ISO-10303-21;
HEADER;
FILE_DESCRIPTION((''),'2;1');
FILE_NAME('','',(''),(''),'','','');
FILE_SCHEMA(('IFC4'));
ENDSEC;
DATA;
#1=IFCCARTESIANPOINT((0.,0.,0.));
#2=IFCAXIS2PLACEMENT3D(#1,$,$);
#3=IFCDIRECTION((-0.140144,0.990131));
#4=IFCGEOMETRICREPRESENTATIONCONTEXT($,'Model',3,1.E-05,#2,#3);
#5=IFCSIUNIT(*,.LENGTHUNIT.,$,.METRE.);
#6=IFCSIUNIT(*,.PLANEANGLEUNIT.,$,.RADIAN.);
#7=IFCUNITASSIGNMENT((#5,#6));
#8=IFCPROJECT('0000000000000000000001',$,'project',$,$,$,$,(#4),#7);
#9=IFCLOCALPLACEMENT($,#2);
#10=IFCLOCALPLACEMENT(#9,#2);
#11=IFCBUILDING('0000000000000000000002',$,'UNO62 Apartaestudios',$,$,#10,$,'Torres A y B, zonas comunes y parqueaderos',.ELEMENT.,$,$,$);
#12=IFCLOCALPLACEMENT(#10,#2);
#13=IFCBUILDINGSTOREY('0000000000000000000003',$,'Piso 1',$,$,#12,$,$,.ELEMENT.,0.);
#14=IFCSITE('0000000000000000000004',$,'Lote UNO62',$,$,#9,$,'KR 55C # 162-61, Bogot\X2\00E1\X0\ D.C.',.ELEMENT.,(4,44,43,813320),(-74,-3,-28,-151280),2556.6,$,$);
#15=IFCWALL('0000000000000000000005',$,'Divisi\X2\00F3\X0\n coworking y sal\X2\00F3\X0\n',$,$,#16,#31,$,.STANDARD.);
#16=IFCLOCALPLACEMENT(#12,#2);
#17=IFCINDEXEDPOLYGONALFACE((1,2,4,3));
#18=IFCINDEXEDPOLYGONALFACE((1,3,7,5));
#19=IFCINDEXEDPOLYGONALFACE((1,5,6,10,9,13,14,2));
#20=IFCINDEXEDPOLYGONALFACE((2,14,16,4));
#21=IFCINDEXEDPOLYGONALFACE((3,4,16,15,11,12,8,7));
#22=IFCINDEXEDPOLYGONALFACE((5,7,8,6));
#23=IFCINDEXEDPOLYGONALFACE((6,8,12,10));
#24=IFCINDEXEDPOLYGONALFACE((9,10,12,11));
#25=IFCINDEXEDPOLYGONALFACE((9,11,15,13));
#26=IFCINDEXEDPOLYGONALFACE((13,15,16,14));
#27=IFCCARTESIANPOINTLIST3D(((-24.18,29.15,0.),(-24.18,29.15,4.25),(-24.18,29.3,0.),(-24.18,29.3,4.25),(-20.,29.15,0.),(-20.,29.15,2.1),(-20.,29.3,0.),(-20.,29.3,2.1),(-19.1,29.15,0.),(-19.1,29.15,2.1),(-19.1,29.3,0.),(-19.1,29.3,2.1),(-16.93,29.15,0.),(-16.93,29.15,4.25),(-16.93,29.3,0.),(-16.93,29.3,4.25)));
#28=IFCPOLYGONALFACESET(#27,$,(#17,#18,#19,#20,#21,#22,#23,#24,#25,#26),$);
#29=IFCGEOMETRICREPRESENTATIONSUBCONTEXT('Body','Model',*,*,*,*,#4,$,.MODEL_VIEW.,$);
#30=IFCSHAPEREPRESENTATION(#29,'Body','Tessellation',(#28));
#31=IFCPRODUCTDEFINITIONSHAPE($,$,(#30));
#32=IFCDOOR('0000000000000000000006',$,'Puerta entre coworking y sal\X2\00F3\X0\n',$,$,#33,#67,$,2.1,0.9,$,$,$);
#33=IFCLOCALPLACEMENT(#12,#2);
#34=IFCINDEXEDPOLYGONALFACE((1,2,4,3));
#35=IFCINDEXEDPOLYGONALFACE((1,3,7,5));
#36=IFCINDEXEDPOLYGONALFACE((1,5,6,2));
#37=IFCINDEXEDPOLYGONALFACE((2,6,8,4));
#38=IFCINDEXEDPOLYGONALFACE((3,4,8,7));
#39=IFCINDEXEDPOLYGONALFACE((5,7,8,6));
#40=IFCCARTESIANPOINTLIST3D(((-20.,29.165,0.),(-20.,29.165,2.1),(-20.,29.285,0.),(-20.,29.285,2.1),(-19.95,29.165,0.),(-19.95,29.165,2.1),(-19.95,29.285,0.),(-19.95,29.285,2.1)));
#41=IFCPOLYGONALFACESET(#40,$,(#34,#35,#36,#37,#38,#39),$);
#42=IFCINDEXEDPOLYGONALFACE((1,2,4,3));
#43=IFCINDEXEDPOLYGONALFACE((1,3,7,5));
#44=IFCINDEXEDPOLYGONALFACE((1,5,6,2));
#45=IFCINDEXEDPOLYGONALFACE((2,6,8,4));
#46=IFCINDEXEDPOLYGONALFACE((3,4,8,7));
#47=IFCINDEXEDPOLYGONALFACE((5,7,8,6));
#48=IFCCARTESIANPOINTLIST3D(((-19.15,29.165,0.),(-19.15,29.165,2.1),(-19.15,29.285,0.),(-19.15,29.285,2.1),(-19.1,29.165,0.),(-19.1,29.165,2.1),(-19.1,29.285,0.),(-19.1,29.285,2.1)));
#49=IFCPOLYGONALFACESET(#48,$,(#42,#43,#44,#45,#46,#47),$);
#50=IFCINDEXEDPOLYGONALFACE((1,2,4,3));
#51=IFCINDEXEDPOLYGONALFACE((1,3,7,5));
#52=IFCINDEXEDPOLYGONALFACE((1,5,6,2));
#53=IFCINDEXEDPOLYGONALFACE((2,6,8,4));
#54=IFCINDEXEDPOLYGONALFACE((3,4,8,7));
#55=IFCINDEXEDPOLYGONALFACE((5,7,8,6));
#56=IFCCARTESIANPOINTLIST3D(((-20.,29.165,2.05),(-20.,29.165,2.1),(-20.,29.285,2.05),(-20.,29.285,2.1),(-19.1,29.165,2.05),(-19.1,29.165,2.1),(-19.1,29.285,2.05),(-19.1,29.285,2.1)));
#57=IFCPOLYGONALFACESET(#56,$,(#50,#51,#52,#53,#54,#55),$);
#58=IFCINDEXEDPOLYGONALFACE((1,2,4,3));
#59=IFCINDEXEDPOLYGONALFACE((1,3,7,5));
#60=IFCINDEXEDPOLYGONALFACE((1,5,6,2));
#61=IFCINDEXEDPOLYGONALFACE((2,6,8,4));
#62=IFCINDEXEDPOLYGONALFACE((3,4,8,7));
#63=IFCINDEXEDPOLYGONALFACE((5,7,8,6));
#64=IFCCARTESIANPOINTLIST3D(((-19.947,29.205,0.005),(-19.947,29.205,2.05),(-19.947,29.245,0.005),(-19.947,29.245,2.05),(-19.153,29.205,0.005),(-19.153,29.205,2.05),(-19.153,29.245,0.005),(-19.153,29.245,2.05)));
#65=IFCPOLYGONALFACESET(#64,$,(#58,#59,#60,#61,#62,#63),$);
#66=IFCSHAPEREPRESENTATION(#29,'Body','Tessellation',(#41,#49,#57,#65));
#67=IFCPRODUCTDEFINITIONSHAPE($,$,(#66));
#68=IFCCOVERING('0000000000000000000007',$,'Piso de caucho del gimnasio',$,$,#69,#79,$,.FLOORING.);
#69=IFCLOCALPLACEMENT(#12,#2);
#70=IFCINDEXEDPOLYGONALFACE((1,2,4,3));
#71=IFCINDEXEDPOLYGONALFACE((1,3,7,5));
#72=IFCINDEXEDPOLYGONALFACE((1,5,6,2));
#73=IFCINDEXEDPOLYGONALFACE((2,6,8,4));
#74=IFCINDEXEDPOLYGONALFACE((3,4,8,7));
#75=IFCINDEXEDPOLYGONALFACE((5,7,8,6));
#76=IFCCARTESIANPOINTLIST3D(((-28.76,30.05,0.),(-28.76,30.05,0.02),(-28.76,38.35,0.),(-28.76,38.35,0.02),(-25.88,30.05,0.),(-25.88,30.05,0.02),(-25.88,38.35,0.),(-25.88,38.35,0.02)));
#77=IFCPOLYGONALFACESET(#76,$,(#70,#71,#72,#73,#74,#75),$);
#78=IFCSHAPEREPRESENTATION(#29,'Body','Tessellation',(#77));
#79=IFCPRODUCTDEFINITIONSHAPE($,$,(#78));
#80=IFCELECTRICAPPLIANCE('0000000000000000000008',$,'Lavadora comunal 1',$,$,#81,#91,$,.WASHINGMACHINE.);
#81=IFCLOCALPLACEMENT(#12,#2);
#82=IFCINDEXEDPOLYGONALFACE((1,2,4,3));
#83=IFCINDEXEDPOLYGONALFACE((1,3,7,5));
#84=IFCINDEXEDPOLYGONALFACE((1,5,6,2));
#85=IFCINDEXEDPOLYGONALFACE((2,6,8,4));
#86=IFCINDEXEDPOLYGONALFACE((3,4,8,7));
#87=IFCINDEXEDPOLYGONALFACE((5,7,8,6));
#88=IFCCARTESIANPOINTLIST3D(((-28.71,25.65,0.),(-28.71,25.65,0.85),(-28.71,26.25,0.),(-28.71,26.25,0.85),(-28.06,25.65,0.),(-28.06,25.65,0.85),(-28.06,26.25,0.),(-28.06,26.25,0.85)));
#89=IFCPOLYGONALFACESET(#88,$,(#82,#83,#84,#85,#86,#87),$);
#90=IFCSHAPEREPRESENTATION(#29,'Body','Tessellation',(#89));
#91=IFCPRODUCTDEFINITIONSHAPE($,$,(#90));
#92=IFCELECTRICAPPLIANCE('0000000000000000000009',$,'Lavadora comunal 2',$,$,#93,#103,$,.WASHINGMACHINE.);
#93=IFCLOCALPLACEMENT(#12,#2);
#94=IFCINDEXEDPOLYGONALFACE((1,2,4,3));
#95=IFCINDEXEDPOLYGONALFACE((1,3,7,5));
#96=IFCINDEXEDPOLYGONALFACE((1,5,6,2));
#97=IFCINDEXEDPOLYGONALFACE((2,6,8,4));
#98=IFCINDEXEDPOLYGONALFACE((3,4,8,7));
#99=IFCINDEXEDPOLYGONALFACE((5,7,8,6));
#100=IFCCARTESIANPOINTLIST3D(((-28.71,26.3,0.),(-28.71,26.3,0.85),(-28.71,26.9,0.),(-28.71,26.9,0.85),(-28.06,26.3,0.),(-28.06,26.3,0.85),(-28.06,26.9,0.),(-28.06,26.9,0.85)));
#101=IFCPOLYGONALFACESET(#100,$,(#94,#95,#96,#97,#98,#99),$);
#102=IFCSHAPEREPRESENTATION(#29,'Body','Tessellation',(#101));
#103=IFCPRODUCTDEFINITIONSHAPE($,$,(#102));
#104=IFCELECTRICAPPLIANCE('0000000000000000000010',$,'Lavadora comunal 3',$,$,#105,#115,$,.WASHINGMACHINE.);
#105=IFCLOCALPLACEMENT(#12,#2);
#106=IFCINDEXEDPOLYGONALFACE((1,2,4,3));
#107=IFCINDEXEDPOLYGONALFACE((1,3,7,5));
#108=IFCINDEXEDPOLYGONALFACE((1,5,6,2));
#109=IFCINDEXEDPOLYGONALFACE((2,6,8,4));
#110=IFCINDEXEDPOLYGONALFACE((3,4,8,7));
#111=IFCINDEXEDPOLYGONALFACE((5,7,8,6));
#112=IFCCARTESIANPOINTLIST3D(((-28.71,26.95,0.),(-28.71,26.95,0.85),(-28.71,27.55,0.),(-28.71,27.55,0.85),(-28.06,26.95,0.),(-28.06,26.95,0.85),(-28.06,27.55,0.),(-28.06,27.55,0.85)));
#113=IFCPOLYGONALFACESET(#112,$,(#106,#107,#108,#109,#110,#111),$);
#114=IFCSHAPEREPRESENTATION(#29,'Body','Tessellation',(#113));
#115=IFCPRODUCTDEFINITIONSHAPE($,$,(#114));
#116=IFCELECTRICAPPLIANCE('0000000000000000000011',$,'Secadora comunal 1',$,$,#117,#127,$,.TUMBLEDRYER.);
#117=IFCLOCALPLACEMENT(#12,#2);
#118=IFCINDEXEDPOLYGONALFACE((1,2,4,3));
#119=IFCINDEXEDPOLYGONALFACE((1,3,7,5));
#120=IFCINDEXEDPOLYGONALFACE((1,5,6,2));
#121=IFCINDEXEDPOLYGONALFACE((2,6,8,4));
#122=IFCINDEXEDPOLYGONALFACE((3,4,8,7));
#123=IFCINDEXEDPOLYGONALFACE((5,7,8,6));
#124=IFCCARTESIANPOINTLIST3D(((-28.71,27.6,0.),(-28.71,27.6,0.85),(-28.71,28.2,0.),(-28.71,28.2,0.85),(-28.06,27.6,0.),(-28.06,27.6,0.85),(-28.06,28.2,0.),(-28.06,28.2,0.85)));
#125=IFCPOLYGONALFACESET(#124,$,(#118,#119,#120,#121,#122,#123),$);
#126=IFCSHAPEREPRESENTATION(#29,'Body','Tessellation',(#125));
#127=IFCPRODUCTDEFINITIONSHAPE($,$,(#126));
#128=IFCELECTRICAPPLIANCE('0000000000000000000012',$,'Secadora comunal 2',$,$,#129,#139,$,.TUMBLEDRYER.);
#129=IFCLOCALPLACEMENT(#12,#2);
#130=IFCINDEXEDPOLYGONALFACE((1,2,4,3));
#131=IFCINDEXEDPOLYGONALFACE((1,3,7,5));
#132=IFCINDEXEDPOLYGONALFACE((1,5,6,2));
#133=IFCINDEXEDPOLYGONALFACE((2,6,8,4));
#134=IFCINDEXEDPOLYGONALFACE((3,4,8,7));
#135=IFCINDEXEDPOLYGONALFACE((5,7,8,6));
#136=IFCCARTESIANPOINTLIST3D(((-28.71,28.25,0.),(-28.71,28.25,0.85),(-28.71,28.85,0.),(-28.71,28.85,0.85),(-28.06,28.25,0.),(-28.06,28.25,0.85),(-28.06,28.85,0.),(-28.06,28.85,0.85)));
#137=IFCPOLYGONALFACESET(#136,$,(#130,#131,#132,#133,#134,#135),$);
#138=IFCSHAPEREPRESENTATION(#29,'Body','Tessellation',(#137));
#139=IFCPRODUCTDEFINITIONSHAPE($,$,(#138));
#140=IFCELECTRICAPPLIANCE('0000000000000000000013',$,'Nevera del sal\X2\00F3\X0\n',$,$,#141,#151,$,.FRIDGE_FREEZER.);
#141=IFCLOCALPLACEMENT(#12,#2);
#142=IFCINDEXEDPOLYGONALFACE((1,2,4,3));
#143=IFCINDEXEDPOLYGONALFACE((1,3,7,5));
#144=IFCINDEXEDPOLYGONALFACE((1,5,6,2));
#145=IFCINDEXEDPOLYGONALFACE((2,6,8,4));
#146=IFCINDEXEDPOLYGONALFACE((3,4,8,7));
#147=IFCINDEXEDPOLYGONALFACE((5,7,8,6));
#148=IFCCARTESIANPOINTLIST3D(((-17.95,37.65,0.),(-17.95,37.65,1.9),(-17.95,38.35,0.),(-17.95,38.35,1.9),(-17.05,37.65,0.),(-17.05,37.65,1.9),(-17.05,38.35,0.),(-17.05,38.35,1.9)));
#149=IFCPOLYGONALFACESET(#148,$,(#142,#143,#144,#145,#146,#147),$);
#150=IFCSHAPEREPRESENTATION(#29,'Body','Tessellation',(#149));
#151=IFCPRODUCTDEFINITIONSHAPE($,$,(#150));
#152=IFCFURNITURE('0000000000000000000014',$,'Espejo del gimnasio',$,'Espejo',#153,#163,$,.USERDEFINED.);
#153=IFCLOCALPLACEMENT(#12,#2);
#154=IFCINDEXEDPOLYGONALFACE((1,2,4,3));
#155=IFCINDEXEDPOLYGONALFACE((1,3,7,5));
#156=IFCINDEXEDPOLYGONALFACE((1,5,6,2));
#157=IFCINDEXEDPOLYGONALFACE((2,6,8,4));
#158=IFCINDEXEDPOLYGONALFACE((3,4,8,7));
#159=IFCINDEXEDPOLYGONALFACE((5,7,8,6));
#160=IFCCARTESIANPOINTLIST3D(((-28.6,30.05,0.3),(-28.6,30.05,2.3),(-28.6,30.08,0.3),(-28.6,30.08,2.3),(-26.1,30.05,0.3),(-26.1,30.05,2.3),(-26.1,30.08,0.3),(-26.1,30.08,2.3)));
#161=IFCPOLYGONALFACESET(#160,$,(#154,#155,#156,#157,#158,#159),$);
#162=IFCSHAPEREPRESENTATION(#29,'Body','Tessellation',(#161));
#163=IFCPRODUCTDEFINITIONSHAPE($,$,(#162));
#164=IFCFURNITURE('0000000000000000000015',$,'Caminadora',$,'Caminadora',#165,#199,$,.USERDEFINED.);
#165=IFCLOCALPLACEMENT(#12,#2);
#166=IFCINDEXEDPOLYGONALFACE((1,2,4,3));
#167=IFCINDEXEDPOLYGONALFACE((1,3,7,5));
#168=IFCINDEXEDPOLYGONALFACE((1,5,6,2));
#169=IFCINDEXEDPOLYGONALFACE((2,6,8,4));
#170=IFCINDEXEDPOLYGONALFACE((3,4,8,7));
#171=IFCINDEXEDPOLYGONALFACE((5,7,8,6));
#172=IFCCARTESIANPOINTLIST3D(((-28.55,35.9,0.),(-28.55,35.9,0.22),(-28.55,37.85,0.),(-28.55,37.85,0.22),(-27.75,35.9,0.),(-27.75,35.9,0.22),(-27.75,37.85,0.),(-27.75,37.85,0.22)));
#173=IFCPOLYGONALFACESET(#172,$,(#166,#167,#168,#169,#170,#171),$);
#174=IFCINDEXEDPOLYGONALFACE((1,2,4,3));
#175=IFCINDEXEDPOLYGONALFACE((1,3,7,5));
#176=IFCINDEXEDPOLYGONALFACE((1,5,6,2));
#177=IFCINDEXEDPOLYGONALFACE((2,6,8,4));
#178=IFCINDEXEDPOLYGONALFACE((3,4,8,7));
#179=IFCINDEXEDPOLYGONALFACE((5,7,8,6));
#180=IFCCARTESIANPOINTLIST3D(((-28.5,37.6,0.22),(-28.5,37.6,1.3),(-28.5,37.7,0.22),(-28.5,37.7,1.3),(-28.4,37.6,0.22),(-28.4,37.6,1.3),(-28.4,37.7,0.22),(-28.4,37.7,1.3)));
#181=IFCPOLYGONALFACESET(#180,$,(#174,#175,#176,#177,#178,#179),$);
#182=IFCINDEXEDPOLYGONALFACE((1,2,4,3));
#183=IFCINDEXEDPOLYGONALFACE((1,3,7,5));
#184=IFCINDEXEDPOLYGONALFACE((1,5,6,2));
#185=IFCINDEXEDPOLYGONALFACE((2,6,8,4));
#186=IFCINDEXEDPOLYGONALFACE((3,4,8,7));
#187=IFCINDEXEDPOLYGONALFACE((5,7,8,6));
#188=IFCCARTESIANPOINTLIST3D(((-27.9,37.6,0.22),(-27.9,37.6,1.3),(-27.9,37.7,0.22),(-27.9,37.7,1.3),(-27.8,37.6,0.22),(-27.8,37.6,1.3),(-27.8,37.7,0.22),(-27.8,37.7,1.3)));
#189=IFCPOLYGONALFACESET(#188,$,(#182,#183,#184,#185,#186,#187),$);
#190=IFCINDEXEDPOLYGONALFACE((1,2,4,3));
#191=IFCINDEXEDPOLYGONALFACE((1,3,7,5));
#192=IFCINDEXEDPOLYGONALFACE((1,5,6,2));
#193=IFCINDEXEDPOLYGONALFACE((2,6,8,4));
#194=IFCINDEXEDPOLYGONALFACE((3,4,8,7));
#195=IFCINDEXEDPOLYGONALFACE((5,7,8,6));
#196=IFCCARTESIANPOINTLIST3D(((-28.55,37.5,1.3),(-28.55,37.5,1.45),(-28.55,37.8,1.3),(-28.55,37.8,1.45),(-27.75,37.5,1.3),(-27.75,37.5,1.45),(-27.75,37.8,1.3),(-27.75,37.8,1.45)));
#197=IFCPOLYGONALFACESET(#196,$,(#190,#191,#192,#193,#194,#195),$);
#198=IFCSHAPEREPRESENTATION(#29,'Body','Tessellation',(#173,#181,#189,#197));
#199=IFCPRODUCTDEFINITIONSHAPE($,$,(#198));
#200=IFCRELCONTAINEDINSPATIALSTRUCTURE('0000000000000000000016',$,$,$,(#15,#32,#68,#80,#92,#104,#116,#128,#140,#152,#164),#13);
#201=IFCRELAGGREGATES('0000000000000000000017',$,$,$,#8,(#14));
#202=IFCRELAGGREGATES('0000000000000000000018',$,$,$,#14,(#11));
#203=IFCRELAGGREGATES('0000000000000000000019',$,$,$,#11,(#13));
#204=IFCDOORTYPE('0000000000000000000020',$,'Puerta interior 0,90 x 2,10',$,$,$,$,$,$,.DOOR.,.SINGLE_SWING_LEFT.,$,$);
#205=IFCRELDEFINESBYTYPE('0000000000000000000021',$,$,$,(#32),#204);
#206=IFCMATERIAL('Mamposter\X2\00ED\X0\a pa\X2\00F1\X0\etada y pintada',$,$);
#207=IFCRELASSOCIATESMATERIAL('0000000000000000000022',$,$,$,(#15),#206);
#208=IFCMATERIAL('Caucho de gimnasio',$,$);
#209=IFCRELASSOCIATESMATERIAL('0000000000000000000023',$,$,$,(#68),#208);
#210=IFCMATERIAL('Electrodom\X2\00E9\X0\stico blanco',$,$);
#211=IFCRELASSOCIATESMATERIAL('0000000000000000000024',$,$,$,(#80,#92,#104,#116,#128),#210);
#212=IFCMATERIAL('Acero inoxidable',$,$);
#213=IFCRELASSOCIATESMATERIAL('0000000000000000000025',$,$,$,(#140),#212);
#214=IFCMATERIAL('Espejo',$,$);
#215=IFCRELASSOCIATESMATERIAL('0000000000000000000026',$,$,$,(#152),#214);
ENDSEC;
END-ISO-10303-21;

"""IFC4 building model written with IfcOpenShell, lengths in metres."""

from ifc_helpers import new_model, si_unit, direction, frame, frame_2d, origin, place, context, subcontext, project, spatial, rectangle, extrude, source, transform, mapped, material, type_object, type_shapes, element, fill, save


model = new_model("IFC4")

# Units and contexts
model_context = context("Model", 3, precision=1e-05, world=origin(), true_north=direction((-0.140144, 0.990131)))
body_context = subcontext(model_context, "Body", "Model", "MODEL_VIEW")
ifc_project = project(units=[si_unit("LENGTHUNIT", "METRE"), si_unit("PLANEANGLEUNIT", "RADIAN")], contexts=[model_context])

# Site, building, storey
site_placement = place(None, origin())
site = spatial("IfcSite", under=ifc_project, at=site_placement, Name="Lote UNO62", LongName="KR 55C # 162-61, Bogotá D.C.", CompositionType="ELEMENT", RefLatitude=(4, 44, 43, 813320), RefLongitude=(-74, -3, -28, -151280), RefElevation=2556.6)
building_placement = place(site_placement, origin())
building = spatial("IfcBuilding", under=site, at=building_placement, Name="UNO62 Apartaestudios", LongName="Torres A y B, zonas comunes y parqueaderos", CompositionType="ELEMENT")
storey_placement = place(building_placement, origin())
storey = spatial("IfcBuildingStorey", under=building, at=storey_placement, Name="Piso 1", CompositionType="ELEMENT", Elevation=0.0)

# Wall, opening, door
ifc_material_1 = material(Name="Mampostería pañetada y pintada")
wall_placement = place(storey_placement, origin())
wall = element("IfcWall", 1, at=wall_placement, inside=storey, material=ifc_material_1, Name="División coworking y salón", PredefinedType="STANDARD", context=body_context, shape_type="SweptSolid", body=[
    extrude(rectangle(XDim=7.25, YDim=0.15, at=frame_2d((-20.555, 29.225))), origin(), (0.0, 0.0, 1.0), 4.25),
])
opening_placement = place(wall_placement, origin())
opening = element("IfcOpeningElement", 2, at=opening_placement, cuts=wall, PredefinedType="OPENING", context=body_context, shape_type="SweptSolid", body=[
    extrude(rectangle(XDim=0.9, YDim=0.25, at=frame_2d((-19.55, 29.225))), origin(), (0.0, 0.0, 1.0), 2.1),
])
door_type = type_object("IfcDoorType", Name="Puerta interior 0,90 x 2,10", OperationType="SINGLE_SWING_LEFT", PredefinedType="DOOR")
shared_shape = source(origin(), body_context, "Body", "SweptSolid", [
    extrude(rectangle(XDim=0.05, YDim=0.12, at=frame_2d((0.025, 0.0))), origin(), (0.0, 0.0, 1.0), 2.1),
    extrude(rectangle(XDim=0.05, YDim=0.12, at=frame_2d((0.875, 0.0))), origin(), (0.0, 0.0, 1.0), 2.1),
    extrude(rectangle(XDim=0.9, YDim=0.12, at=frame_2d((0.45, 0.0))), frame((0.0, 0.0, 2.05)), (0.0, 0.0, 1.0), 0.05),
    extrude(rectangle(XDim=0.794, YDim=0.04, at=frame_2d((0.45, 0.0))), frame((0.0, 0.0, 0.005)), (0.0, 0.0, 1.0), 2.045),
])
type_shapes(door_type, [shared_shape])
door_placement = place(storey_placement, frame((-20.0, 29.225, 0.0), z_axis=(0.0, 0.0, 1.0), x_axis=(1.0, 0.0, 0.0)))
door = element("IfcDoor", 3, at=door_placement, inside=storey, type_object=door_type, Name="Puerta entre coworking y salón", OverallHeight=2.1, OverallWidth=0.9, context=body_context, shape_type="MappedRepresentation", body=[
    mapped(shared_shape, transform((0.0, 0.0, 0.0))),
])
fill(opening, door)

# Covering
ifc_material_2 = material(Name="Caucho de gimnasio")
covering_placement = place(storey_placement, origin())
element("IfcCovering", 4, at=covering_placement, inside=storey, material=ifc_material_2, Name="Piso de caucho del gimnasio", PredefinedType="FLOORING", context=body_context, shape_type="SweptSolid", body=[
    extrude(rectangle(XDim=2.88, YDim=8.3, at=frame_2d((-27.32, 34.2))), origin(), (0.0, 0.0, 1.0), 0.02),
])

# Electric appliances
ifc_material_3 = material(Name="Electrodoméstico blanco")
electric_appliance_1_placement = place(storey_placement, origin())
element("IfcElectricAppliance", 5, at=electric_appliance_1_placement, inside=storey, material=ifc_material_3, Name="Lavadora comunal 1", PredefinedType="WASHINGMACHINE", context=body_context, shape_type="SweptSolid", body=[
    extrude(rectangle(XDim=0.65, YDim=0.6, at=frame_2d((-28.385, 25.95))), origin(), (0.0, 0.0, 1.0), 0.85),
])
electric_appliance_2_placement = place(storey_placement, origin())
element("IfcElectricAppliance", 6, at=electric_appliance_2_placement, inside=storey, material=ifc_material_3, Name="Lavadora comunal 2", PredefinedType="WASHINGMACHINE", context=body_context, shape_type="SweptSolid", body=[
    extrude(rectangle(XDim=0.65, YDim=0.6, at=frame_2d((-28.385, 26.6))), origin(), (0.0, 0.0, 1.0), 0.85),
])
electric_appliance_3_placement = place(storey_placement, origin())
element("IfcElectricAppliance", 7, at=electric_appliance_3_placement, inside=storey, material=ifc_material_3, Name="Lavadora comunal 3", PredefinedType="WASHINGMACHINE", context=body_context, shape_type="SweptSolid", body=[
    extrude(rectangle(XDim=0.65, YDim=0.6, at=frame_2d((-28.385, 27.25))), origin(), (0.0, 0.0, 1.0), 0.85),
])
electric_appliance_4_placement = place(storey_placement, origin())
element("IfcElectricAppliance", 8, at=electric_appliance_4_placement, inside=storey, material=ifc_material_3, Name="Secadora comunal 1", PredefinedType="TUMBLEDRYER", context=body_context, shape_type="SweptSolid", body=[
    extrude(rectangle(XDim=0.65, YDim=0.6, at=frame_2d((-28.385, 27.9))), origin(), (0.0, 0.0, 1.0), 0.85),
])
electric_appliance_5_placement = place(storey_placement, origin())
element("IfcElectricAppliance", 9, at=electric_appliance_5_placement, inside=storey, material=ifc_material_3, Name="Secadora comunal 2", PredefinedType="TUMBLEDRYER", context=body_context, shape_type="SweptSolid", body=[
    extrude(rectangle(XDim=0.65, YDim=0.6, at=frame_2d((-28.385, 28.55))), origin(), (0.0, 0.0, 1.0), 0.85),
])
ifc_material_4 = material(Name="Acero inoxidable")
electric_appliance_6_placement = place(storey_placement, origin())
element("IfcElectricAppliance", 10, at=electric_appliance_6_placement, inside=storey, material=ifc_material_4, Name="Nevera del salón", PredefinedType="FRIDGE_FREEZER", context=body_context, shape_type="SweptSolid", body=[
    extrude(rectangle(XDim=0.9, YDim=0.7, at=frame_2d((-17.5, 38.0))), origin(), (0.0, 0.0, 1.0), 1.9),
])

# Furniture
ifc_material_5 = material(Name="Espejo")
furniture_1_placement = place(storey_placement, origin())
element("IfcFurniture", 11, at=furniture_1_placement, inside=storey, material=ifc_material_5, Name="Espejo del gimnasio", ObjectType="Espejo", PredefinedType="USERDEFINED", context=body_context, shape_type="SweptSolid", body=[
    extrude(rectangle(XDim=2.5, YDim=0.03, at=frame_2d((-27.35, 30.065))), frame((0.0, 0.0, 0.3)), (0.0, 0.0, 1.0), 2.0),
])
furniture_2_placement = place(storey_placement, origin())
element("IfcFurniture", 12, at=furniture_2_placement, inside=storey, Name="Caminadora", ObjectType="Caminadora", PredefinedType="USERDEFINED", context=body_context, shape_type="SweptSolid", body=[
    extrude(rectangle(XDim=0.8, YDim=1.95, at=frame_2d((-28.15, 36.875))), origin(), (0.0, 0.0, 1.0), 0.22),
    extrude(rectangle(XDim=0.1, YDim=0.1, at=frame_2d((-28.45, 37.65))), frame((0.0, 0.0, 0.22)), (0.0, 0.0, 1.0), 1.08),
    extrude(rectangle(XDim=0.1, YDim=0.1, at=frame_2d((-27.85, 37.65))), frame((0.0, 0.0, 0.22)), (0.0, 0.0, 1.0), 1.08),
    extrude(rectangle(XDim=0.8, YDim=0.3, at=frame_2d((-28.15, 37.65))), frame((0.0, 0.0, 1.3)), (0.0, 0.0, 1.0), 0.15),
])

save(model, "model.ifc")
